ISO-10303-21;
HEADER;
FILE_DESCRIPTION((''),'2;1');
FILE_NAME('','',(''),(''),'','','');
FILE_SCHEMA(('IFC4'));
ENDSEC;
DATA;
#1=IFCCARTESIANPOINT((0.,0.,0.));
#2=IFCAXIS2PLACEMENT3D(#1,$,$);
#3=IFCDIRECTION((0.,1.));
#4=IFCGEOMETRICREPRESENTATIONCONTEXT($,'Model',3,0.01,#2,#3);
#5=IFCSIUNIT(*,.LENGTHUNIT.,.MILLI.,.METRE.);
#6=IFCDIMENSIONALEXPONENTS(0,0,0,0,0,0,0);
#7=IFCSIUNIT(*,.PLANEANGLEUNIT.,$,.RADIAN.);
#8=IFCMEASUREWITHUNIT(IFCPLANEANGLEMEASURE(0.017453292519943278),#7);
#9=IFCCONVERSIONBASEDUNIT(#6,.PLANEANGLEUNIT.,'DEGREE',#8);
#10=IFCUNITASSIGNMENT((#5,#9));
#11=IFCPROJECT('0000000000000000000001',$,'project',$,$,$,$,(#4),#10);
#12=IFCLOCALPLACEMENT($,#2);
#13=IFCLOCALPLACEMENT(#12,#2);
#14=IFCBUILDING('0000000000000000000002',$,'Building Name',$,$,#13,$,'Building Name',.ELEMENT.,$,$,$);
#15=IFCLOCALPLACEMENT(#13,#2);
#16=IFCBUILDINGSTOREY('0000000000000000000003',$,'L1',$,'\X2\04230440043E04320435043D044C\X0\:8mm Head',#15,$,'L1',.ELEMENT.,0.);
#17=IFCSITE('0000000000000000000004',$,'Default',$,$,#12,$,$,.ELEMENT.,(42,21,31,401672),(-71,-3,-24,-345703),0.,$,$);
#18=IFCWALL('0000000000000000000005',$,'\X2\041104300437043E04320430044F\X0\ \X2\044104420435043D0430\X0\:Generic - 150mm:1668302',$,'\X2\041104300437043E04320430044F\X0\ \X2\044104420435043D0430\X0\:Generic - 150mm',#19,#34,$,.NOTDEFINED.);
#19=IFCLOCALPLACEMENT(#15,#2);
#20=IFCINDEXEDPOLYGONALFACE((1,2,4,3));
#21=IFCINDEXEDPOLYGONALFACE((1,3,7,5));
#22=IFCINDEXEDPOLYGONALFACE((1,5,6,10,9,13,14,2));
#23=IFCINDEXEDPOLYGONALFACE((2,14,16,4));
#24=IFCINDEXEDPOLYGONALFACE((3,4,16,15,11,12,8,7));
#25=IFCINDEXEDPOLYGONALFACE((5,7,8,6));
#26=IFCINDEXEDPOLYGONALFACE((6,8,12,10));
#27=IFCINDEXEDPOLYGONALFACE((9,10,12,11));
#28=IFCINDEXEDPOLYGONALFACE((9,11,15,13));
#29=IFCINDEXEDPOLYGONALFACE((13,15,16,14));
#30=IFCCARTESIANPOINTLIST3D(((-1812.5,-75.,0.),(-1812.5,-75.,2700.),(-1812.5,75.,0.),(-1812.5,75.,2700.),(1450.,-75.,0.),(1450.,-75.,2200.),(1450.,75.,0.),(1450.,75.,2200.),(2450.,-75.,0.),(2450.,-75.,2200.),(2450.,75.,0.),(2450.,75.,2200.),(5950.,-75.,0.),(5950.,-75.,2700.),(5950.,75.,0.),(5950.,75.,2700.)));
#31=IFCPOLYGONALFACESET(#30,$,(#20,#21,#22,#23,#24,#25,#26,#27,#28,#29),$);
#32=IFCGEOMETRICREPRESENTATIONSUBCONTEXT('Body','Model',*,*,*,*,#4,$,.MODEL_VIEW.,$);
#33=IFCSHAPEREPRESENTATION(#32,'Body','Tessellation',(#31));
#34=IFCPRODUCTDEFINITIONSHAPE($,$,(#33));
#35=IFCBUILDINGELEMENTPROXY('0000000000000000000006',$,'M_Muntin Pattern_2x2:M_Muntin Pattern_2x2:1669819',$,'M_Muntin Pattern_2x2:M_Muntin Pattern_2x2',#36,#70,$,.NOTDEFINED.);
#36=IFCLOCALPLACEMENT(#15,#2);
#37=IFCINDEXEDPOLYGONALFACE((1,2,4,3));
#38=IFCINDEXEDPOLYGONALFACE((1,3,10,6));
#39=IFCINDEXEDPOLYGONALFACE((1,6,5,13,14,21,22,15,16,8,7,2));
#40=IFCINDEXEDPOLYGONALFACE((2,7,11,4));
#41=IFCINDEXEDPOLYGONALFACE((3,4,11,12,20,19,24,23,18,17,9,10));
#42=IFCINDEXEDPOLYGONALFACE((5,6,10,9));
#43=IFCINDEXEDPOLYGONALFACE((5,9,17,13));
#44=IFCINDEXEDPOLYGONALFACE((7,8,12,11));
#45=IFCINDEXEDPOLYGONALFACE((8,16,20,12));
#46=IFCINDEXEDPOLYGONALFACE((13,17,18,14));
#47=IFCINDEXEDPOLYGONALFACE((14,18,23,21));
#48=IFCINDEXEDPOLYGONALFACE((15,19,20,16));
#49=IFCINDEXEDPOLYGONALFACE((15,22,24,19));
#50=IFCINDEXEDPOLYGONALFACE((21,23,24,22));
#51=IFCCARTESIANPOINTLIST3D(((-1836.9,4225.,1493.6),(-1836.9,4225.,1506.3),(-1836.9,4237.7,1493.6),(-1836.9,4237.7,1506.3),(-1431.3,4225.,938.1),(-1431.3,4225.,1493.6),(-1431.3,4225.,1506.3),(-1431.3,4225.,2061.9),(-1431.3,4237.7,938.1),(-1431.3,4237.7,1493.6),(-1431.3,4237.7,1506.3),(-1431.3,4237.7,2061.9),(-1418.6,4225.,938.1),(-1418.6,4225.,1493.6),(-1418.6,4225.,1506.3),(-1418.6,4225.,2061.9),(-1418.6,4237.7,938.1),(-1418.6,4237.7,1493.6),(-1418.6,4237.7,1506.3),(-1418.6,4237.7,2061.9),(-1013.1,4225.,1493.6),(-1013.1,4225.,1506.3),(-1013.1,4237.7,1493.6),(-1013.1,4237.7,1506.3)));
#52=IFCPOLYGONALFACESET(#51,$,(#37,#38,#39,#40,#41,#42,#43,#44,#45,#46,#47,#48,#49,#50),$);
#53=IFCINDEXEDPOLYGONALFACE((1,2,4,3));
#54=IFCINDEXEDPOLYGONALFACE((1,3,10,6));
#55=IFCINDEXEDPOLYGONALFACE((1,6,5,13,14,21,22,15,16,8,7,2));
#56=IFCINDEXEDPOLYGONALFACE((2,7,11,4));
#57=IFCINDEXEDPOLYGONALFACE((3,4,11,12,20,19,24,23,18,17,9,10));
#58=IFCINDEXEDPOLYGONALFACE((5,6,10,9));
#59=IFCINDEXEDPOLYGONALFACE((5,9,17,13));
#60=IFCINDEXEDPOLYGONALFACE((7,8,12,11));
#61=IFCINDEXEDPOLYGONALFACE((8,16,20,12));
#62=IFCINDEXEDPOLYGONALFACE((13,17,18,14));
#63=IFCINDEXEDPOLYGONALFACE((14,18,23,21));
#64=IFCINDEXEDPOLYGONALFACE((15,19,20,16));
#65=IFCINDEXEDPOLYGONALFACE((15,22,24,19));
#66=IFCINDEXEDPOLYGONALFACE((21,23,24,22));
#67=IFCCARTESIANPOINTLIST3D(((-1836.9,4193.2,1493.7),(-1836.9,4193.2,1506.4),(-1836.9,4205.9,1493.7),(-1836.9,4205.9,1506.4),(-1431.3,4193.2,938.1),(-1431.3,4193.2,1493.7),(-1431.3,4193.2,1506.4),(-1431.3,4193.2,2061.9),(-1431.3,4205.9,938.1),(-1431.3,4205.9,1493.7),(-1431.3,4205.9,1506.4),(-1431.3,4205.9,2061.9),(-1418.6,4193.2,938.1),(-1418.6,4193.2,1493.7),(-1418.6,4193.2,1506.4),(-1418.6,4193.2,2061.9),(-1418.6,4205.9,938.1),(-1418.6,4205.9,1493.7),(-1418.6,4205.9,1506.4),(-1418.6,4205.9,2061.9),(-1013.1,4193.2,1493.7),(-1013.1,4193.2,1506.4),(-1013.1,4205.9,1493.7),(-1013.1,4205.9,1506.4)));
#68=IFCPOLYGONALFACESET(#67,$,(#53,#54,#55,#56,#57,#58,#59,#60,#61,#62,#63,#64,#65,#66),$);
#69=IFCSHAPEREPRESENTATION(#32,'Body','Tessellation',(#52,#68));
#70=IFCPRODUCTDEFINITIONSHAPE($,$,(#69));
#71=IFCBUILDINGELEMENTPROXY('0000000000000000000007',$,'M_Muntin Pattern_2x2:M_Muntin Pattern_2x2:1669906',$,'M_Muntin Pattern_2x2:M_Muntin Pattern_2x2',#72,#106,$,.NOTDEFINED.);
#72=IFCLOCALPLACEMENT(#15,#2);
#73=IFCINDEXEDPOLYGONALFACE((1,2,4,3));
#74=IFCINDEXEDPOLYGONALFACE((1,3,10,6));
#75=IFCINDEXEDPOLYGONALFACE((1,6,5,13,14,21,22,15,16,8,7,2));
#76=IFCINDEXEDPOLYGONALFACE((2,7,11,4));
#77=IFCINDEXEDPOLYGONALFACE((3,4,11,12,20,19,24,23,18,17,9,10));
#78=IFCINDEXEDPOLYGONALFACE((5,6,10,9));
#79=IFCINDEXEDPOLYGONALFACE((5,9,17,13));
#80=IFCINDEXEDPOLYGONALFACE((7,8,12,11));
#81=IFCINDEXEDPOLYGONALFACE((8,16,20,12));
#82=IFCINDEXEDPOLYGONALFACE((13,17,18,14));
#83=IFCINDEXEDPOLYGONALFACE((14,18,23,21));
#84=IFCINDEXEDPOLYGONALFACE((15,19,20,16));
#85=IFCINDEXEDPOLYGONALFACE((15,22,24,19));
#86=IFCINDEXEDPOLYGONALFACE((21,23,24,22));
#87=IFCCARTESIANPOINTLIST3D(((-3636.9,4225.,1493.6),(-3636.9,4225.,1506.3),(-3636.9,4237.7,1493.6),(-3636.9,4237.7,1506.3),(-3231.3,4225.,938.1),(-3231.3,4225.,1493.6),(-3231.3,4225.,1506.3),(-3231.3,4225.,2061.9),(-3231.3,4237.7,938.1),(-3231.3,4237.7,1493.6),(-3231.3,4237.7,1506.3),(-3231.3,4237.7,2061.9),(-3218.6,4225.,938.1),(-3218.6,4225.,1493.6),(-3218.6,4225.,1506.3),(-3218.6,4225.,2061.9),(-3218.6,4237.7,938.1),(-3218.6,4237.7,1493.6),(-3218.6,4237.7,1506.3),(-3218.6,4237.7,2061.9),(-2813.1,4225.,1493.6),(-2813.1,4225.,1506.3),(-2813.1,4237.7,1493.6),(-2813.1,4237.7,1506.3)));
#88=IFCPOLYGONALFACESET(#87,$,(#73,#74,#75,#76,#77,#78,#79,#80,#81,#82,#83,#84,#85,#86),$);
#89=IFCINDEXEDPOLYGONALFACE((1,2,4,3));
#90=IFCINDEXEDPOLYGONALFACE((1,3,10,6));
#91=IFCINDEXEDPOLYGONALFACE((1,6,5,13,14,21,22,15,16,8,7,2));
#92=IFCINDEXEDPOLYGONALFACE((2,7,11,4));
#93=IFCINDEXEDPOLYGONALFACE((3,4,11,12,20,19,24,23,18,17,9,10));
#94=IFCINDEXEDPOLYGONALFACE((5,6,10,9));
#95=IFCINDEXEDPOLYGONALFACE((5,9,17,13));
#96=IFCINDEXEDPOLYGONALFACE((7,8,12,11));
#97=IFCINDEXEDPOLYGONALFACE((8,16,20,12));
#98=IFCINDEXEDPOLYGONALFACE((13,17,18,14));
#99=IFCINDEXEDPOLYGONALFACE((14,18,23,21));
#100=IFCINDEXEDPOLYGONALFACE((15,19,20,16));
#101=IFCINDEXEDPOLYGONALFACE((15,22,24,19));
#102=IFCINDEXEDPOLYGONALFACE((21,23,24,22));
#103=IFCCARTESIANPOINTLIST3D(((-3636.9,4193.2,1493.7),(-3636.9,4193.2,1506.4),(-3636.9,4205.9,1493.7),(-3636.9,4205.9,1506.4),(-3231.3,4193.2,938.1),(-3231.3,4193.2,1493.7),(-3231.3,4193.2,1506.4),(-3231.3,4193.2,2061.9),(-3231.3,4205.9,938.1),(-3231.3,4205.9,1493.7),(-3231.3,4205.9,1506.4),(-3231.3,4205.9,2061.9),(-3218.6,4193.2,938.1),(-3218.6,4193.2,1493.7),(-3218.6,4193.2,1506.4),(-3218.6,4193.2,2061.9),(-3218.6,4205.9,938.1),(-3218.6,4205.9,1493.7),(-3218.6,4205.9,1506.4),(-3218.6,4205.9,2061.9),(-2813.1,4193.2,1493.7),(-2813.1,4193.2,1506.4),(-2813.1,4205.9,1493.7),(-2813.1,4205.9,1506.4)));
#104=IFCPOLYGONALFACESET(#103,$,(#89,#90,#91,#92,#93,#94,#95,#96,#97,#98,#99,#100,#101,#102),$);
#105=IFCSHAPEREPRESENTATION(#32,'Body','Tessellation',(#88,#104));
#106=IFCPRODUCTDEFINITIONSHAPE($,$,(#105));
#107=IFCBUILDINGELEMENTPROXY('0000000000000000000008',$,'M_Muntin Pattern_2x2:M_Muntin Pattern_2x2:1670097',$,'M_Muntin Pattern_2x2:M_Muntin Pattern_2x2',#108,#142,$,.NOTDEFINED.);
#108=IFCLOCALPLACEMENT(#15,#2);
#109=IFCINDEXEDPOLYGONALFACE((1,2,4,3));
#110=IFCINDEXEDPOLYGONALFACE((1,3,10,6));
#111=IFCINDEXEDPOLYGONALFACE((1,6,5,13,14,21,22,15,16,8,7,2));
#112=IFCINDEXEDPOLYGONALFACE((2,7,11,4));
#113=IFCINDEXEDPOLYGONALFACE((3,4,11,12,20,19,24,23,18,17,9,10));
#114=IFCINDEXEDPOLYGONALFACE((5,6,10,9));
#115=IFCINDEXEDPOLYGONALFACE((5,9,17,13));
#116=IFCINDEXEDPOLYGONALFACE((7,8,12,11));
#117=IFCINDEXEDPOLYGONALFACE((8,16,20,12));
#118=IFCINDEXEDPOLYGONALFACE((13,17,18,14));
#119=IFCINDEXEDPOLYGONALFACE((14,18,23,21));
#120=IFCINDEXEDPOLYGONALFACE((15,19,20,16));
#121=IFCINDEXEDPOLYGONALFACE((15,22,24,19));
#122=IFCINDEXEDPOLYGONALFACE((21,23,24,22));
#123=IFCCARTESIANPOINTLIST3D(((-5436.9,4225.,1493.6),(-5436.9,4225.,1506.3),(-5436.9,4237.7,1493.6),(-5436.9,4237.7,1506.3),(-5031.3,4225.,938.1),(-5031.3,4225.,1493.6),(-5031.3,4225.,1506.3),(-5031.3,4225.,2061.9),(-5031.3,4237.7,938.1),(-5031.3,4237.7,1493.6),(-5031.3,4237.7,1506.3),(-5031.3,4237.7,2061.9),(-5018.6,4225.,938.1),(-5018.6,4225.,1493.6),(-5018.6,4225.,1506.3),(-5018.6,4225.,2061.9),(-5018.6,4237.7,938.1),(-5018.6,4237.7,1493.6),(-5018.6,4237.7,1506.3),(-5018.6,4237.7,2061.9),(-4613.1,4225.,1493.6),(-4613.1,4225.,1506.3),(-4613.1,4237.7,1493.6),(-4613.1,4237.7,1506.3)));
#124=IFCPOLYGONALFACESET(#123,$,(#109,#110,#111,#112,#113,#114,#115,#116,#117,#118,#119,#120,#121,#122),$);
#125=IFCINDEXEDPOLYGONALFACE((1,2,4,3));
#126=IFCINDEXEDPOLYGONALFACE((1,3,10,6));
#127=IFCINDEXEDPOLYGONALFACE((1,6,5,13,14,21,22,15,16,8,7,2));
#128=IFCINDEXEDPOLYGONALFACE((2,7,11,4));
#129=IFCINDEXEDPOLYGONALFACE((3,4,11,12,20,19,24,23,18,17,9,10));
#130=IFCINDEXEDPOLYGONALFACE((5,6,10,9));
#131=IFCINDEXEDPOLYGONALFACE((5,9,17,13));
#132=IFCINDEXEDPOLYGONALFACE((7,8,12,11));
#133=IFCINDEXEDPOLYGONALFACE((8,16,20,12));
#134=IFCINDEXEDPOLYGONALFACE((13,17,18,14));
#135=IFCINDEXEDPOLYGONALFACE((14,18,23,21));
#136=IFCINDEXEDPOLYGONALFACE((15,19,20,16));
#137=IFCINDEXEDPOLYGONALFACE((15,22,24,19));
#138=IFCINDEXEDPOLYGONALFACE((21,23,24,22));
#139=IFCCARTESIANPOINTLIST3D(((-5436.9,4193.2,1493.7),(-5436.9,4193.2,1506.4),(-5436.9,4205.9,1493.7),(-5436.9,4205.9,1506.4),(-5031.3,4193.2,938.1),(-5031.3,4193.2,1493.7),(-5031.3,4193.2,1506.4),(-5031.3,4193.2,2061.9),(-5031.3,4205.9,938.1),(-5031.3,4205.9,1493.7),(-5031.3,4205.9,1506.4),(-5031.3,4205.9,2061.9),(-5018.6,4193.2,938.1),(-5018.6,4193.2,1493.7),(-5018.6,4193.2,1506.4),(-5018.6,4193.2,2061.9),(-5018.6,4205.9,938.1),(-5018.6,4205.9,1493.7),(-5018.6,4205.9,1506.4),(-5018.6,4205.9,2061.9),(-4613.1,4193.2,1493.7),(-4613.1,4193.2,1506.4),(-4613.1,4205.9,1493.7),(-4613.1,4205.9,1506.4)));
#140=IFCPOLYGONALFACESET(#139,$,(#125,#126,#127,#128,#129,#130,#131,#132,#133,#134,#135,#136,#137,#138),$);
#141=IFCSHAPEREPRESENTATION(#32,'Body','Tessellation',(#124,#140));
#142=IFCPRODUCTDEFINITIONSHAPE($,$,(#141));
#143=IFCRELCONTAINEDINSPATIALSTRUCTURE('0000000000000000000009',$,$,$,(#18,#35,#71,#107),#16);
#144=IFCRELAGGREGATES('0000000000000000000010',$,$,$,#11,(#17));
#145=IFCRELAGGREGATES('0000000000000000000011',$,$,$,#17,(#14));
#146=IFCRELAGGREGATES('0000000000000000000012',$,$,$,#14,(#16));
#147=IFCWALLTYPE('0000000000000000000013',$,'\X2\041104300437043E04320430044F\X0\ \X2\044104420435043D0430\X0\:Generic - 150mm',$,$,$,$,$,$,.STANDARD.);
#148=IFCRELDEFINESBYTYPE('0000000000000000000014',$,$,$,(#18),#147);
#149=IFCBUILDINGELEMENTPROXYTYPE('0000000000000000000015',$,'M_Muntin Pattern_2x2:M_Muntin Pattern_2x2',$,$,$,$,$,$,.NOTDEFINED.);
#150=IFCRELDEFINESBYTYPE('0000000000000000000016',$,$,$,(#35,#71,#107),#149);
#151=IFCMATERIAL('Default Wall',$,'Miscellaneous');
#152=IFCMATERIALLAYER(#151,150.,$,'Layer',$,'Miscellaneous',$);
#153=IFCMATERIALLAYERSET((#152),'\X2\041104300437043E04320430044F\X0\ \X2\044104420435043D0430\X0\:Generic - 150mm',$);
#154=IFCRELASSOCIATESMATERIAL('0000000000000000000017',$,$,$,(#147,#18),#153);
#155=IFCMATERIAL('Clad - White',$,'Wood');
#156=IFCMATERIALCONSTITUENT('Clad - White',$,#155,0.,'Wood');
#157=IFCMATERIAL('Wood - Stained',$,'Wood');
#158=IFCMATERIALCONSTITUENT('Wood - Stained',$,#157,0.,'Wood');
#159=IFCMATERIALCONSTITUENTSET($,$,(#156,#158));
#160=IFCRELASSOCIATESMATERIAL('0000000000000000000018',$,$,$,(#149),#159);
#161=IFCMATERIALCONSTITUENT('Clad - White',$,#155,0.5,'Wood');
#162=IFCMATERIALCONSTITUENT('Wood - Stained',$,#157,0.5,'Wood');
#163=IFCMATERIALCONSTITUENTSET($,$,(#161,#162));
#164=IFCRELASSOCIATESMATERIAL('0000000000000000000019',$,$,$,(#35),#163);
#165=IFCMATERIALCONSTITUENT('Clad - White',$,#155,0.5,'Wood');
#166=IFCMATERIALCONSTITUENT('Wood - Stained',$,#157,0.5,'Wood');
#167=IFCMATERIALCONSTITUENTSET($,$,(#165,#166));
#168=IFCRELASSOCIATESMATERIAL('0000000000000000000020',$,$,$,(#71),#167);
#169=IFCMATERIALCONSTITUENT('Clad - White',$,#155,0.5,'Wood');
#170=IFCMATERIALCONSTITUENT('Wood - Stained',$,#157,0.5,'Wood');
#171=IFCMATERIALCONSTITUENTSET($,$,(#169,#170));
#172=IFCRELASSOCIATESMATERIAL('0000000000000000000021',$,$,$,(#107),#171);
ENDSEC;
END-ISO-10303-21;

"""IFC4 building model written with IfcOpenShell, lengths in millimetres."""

from ifc_helpers import new_model, entity, si_unit, converted_unit, direction, frame, frame_2d, origin, place, context, subcontext, project, spatial, polyline, rectangle, outline, extrude, source, transform, mapped, material, layer, layer_set, layer_usage, constituent, constituent_set, type_object, type_shapes, element, save


model = new_model("IFC4")

# Units and contexts
model_context = context("Model", 3, precision=0.01, world=origin(), true_north=direction((0.0, 1.0)))
body_context = subcontext(model_context, "Body", "Model", "MODEL_VIEW")
ifc_project = project(units=[si_unit("LENGTHUNIT", "METRE", prefix="MILLI"), converted_unit("PLANEANGLEUNIT", "DEGREE", entity("IfcPlaneAngleMeasure", 0.017453292519943278), si_unit("PLANEANGLEUNIT", "RADIAN"), dimensions=[0, 0, 0, 0, 0, 0, 0])], contexts=[model_context])

# Site, building, storey
site_placement = place(None, origin())
site = spatial("IfcSite", under=ifc_project, at=site_placement, Name="Default", CompositionType="ELEMENT", RefLatitude=(42, 21, 31, 401672), RefLongitude=(-71, -3, -24, -345703), RefElevation=0.0)
building_placement = place(site_placement, origin())
building = spatial("IfcBuilding", under=site, at=building_placement, Name="Building Name", LongName="Building Name", CompositionType="ELEMENT")
storey_placement = place(building_placement, origin())
storey = spatial("IfcBuildingStorey", under=building, at=storey_placement, Name="L1", ObjectType="Уровень:8mm Head", LongName="L1", CompositionType="ELEMENT", Elevation=0.0)

# Shared definitions
ifc_material_1 = material(Name="Default Wall", Category="Miscellaneous")
ifc_layer_1 = layer(ifc_material_1, 150.0, Name="Layer", Category="Miscellaneous")
ifc_layer_set_1 = layer_set([ifc_layer_1], Name="Базовая стена:Generic - 150mm")
wall_type = type_object("IfcWallType", Name="Базовая стена:Generic - 150mm", PredefinedType="STANDARD", material=ifc_layer_set_1)

# Wall, openings
ifc_layer_usage_1 = layer_usage(ifc_layer_set_1, "AXIS2", "NEGATIVE", 75.0)
wall_1_placement = place(storey_placement, frame((5950.0, 0.0, 0.0), z_axis=(0.0, 0.0, 1.0), x_axis=(-1.0, 0.0, 0.0)))
wall_1 = element("IfcWall", 1, at=wall_1_placement, inside=storey, type_object=wall_type, material=ifc_layer_usage_1, Name="Базовая стена:Generic - 150mm:1668302", ObjectType="Базовая стена:Generic - 150mm", PredefinedType="NOTDEFINED", context=body_context, shape_type="SweptSolid", body=[
    extrude(rectangle(XDim=7762.5, YDim=150.0, at=frame_2d((3881.2, 0.0), x_axis=(1.0, 0.0))), origin(), (0.0, 0.0, 1.0), 2700.0),
])
opening_1_placement = place(wall_1_placement, frame((4500.0, 75.0, 0.0)))
element("IfcOpeningElement", 2, at=opening_1_placement, cuts=wall_1, PredefinedType="OPENING", context=body_context, shape_type="SweptSolid", body=[
    extrude(rectangle(XDim=2200.0, YDim=1000.0, at=frame_2d((1100.0, 500.0), x_axis=(1.0, 0.0))), frame((0.0, 0.0, 0.0), z_axis=(0.0, -1.0, 0.0), x_axis=(0.0, 0.0, 1.0)), (0.0, 0.0, 1.0), 150.0),
])
opening_2_placement = place(wall_1_placement, frame((5950.0, 0.0, 0.0), z_axis=(0.0, 0.0, 1.0), x_axis=(-1.0, 0.0, 0.0)))
element("IfcOpeningElement", 3, at=opening_2_placement, cuts=wall_1, PredefinedType="OPENING", context=body_context, shape_type="SweptSolid", body=[
    extrude(rectangle(XDim=2200.0, YDim=1000.0, at=frame_2d((0.0, 0.0), x_axis=(1.0, 0.0))), frame((1950.0, 1449.0, 1100.0), z_axis=(0.0, -1.0, 0.0), x_axis=(0.0, 0.0, 1.0)), (0.0, 0.0, 1.0), 3048.0),
])

# Building element proxies
ifc_material_2 = material(Name="Clad - White", Category="Wood")
ifc_constituent_1 = constituent(ifc_material_2, Name="Clad - White", Category="Wood", fraction=0.5)
ifc_material_3 = material(Name="Wood - Stained", Category="Wood")
ifc_constituent_2 = constituent(ifc_material_3, Name="Wood - Stained", Category="Wood", fraction=0.5)
ifc_constituent_set_1 = constituent_set(constituents=[ifc_constituent_1, ifc_constituent_2])
ifc_constituent_3 = constituent(ifc_material_2, Name="Clad - White", Category="Wood", fraction=0.0)
ifc_constituent_4 = constituent(ifc_material_3, Name="Wood - Stained", Category="Wood", fraction=0.0)
ifc_constituent_set_2 = constituent_set(constituents=[ifc_constituent_3, ifc_constituent_4])
building_element_proxy_type_1 = type_object("IfcBuildingElementProxyType", Name="M_Muntin Pattern_2x2:M_Muntin Pattern_2x2", PredefinedType="NOTDEFINED", material=ifc_constituent_set_2)
shared_shape_1 = source(origin(), body_context, "Body", "SweptSolid", [
    extrude(outline(polyline([(6.4, -6.4), (561.9, -6.4), (561.9, 6.3), (6.4, 6.3), (6.4, 411.9), (-6.3, 411.9), (-6.3, 6.3), (-561.9, 6.3), (-561.9, -6.4), (-6.3, -6.4), (-6.3, -411.9), (6.4, -411.9), (6.4, -6.4)])), frame((0.0, -22.2, 561.9), z_axis=(0.0, 1.0, 0.0), x_axis=(0.0, 0.0, 1.0)), (0.0, 0.0, 1.0), 12.7),
    extrude(outline(polyline([(6.4, -6.4), (561.9, -6.4), (561.9, 6.3), (6.4, 6.3), (6.4, 411.9), (-6.3, 411.9), (-6.3, 6.3), (-561.9, 6.3), (-561.9, -6.4), (-6.3, -6.4), (-6.3, -411.9), (6.4, -411.9), (6.4, -6.4)])), frame((0.0, 9.5, 561.9), z_axis=(0.0, 1.0, 0.0), x_axis=(0.0, 0.0, 1.0)), (0.0, 0.0, 1.0), 12.7),
])
type_shapes(building_element_proxy_type_1, [shared_shape_1])
proxy_1_placement = place(storey_placement, frame((-1425.0, 4215.5, 938.1), z_axis=(0.0, 0.0, 1.0), x_axis=(-1.0, 0.0, 0.0)))
element("IfcBuildingElementProxy", 4, at=proxy_1_placement, inside=storey, type_object=building_element_proxy_type_1, material=ifc_constituent_set_1, Name="M_Muntin Pattern_2x2:M_Muntin Pattern_2x2:1669819", ObjectType="M_Muntin Pattern_2x2:M_Muntin Pattern_2x2", PredefinedType="NOTDEFINED", context=body_context, shape_type="MappedRepresentation", body=[
    mapped(shared_shape_1, transform((0.0, 0.0, 0.0), scale=1.0)),
])
ifc_constituent_5 = constituent(ifc_material_2, Name="Clad - White", Category="Wood", fraction=0.5)
ifc_constituent_6 = constituent(ifc_material_3, Name="Wood - Stained", Category="Wood", fraction=0.5)
ifc_constituent_set_3 = constituent_set(constituents=[ifc_constituent_5, ifc_constituent_6])
proxy_2_placement = place(storey_placement, frame((-3225.0, 4215.5, 938.1), z_axis=(0.0, 0.0, 1.0), x_axis=(-1.0, 0.0, 0.0)))
element("IfcBuildingElementProxy", 5, at=proxy_2_placement, inside=storey, type_object=building_element_proxy_type_1, material=ifc_constituent_set_3, Name="M_Muntin Pattern_2x2:M_Muntin Pattern_2x2:1669906", ObjectType="M_Muntin Pattern_2x2:M_Muntin Pattern_2x2", PredefinedType="NOTDEFINED", context=body_context, shape_type="MappedRepresentation", body=[
    mapped(shared_shape_1, transform((0.0, 0.0, 0.0), scale=1.0)),
])
ifc_constituent_7 = constituent(ifc_material_2, Name="Clad - White", Category="Wood", fraction=0.5)
ifc_constituent_8 = constituent(ifc_material_3, Name="Wood - Stained", Category="Wood", fraction=0.5)
ifc_constituent_set_4 = constituent_set(constituents=[ifc_constituent_7, ifc_constituent_8])
proxy_3_placement = place(storey_placement, frame((-5025.0, 4215.5, 938.1), z_axis=(0.0, 0.0, 1.0), x_axis=(-1.0, 0.0, 0.0)))
element("IfcBuildingElementProxy", 6, at=proxy_3_placement, inside=storey, type_object=building_element_proxy_type_1, material=ifc_constituent_set_4, Name="M_Muntin Pattern_2x2:M_Muntin Pattern_2x2:1670097", ObjectType="M_Muntin Pattern_2x2:M_Muntin Pattern_2x2", PredefinedType="NOTDEFINED", context=body_context, shape_type="MappedRepresentation", body=[
    mapped(shared_shape_1, transform((0.0, 0.0, 0.0), scale=1.0)),
])

save(model, "model.ifc")
